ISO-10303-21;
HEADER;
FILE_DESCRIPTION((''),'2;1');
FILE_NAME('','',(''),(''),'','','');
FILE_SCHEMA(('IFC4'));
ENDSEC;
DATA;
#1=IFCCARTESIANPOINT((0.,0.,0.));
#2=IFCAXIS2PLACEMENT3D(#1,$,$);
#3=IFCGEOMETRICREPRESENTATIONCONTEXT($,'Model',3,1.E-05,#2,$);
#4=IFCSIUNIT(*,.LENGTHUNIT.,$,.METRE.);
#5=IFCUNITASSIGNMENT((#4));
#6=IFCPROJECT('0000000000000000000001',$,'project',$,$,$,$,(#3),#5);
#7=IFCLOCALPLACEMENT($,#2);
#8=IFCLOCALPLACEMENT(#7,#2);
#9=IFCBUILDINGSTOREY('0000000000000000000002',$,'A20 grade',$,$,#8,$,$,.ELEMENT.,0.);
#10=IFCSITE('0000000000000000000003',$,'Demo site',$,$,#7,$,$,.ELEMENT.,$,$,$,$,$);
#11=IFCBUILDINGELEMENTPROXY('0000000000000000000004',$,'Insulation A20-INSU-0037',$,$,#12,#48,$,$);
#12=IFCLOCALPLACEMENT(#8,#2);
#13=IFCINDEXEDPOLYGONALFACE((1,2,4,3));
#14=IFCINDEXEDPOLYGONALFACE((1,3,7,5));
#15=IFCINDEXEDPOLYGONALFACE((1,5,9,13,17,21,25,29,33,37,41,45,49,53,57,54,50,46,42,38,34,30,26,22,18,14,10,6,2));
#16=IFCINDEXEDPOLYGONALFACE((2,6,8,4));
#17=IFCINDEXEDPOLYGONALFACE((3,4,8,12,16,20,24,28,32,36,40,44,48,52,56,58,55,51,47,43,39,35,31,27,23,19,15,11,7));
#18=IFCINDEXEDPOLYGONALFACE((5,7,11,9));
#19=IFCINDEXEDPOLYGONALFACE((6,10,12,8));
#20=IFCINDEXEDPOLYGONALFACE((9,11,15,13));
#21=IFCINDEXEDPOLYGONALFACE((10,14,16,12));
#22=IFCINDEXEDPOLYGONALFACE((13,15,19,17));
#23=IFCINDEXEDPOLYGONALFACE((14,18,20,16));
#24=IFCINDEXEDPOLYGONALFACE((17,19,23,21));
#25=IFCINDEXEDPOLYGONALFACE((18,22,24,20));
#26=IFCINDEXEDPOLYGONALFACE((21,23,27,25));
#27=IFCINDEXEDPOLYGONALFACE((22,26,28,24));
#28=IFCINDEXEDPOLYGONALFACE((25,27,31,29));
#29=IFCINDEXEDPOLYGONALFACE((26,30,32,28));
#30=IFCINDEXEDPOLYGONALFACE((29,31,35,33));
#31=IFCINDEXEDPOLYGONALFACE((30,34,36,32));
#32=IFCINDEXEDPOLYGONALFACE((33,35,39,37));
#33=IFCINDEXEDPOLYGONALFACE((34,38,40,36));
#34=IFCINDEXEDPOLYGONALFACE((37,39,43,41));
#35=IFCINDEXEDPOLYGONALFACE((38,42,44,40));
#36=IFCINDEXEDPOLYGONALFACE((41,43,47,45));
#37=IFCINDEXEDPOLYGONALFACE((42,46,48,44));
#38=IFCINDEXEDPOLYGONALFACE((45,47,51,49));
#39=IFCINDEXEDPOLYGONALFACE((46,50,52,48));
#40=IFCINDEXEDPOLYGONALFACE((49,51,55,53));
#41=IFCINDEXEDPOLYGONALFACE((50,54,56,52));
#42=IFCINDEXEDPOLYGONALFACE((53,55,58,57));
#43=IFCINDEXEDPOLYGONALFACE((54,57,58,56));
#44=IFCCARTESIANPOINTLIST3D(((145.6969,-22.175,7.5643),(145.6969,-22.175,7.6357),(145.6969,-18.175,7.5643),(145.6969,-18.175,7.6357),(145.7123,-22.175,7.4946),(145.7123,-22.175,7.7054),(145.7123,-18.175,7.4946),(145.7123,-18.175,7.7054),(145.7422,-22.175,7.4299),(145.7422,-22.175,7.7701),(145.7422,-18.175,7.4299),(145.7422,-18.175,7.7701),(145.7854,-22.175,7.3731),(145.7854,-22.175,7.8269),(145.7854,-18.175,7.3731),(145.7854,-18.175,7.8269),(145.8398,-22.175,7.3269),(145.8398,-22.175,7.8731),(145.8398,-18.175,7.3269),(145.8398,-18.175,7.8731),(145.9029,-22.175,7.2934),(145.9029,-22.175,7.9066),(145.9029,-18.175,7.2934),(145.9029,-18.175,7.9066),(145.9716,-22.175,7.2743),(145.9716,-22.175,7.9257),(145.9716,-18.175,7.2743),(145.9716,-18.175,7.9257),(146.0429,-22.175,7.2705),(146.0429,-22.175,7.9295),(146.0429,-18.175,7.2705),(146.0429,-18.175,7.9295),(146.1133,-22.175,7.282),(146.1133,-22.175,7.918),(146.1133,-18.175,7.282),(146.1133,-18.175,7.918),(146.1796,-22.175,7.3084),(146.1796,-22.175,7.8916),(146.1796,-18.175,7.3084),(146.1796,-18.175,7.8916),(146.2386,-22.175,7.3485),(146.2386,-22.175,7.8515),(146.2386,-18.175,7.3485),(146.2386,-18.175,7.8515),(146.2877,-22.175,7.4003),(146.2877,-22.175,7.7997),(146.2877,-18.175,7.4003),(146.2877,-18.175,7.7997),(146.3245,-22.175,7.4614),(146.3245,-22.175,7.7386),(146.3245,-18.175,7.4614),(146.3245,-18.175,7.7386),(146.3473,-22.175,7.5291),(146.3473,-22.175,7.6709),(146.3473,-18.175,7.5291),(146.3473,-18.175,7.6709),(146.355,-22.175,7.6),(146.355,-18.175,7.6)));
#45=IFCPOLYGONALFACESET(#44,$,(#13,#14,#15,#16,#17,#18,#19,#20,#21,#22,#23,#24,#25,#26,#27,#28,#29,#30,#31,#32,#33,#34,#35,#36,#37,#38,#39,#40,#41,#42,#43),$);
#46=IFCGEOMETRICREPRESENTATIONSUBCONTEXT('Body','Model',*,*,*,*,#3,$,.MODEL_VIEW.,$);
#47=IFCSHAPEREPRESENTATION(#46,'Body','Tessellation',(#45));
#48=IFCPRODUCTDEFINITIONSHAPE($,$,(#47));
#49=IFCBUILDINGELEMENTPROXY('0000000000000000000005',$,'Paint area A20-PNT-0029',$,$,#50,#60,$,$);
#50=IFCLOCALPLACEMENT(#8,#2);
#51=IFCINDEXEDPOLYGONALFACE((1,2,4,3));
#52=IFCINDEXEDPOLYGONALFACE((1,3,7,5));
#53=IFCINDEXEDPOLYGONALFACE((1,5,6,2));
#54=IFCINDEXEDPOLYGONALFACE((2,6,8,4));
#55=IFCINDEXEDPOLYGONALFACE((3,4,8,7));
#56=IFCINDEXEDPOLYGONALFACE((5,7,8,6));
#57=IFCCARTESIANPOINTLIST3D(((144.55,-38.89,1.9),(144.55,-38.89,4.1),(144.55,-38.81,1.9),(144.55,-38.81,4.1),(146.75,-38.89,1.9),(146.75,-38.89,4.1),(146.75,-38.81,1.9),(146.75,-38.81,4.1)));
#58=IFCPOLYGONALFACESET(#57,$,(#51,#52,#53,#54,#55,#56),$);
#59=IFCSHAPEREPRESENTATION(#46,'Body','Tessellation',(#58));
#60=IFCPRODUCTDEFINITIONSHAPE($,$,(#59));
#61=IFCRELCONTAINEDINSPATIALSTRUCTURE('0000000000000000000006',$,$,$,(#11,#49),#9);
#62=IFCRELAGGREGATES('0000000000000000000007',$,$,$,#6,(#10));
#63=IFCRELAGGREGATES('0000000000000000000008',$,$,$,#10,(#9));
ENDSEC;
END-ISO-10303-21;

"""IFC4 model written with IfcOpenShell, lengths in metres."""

from ifc_helpers import new_model, si_unit, frame, origin, place, context, subcontext, project, spatial, rectangle, circle, extrude, element, save


model = new_model("IFC4")

# Units and contexts
model_context = context("Model", 3, precision=1e-05, world=origin())
body_context = subcontext(model_context, "Body", "Model", "MODEL_VIEW")
ifc_project = project(units=[si_unit("LENGTHUNIT", "METRE")], contexts=[model_context])

# Site, storey
site_placement = place(None, origin())
site = spatial("IfcSite", under=ifc_project, at=site_placement, Name="Demo site", CompositionType="ELEMENT")
storey_placement = place(site_placement, origin())
storey = spatial("IfcBuildingStorey", under=site, at=storey_placement, Name="A20 grade", CompositionType="ELEMENT", Elevation=0.0)

# Building element proxies
for number, where, name in (
    (1, (146.025, -22.175, 7.6), "Insulation A20-INSU-0037"),
):
    element("IfcBuildingElementProxy", number, at=place(storey_placement, frame(where)), inside=storey, Name=name, context=body_context, shape_type="SweptSolid", body=[
        extrude(circle(Radius=0.33), frame((0.0, 0.0, 0.0), z_axis=(0.0, 1.0, 0.0), x_axis=(1.0, 0.0, 0.0)), (0.0, 0.0, 1.0), 4.0),
    ])
proxy_placement = place(storey_placement, frame((145.65, -38.85, 1.9)))
element("IfcBuildingElementProxy", 2, at=proxy_placement, inside=storey, Name="Paint area A20-PNT-0029", context=body_context, shape_type="SweptSolid", body=[
    extrude(rectangle(XDim=2.2, YDim=0.08), origin(), (0.0, 0.0, 1.0), 2.2),
])

save(model, "model.ifc")
